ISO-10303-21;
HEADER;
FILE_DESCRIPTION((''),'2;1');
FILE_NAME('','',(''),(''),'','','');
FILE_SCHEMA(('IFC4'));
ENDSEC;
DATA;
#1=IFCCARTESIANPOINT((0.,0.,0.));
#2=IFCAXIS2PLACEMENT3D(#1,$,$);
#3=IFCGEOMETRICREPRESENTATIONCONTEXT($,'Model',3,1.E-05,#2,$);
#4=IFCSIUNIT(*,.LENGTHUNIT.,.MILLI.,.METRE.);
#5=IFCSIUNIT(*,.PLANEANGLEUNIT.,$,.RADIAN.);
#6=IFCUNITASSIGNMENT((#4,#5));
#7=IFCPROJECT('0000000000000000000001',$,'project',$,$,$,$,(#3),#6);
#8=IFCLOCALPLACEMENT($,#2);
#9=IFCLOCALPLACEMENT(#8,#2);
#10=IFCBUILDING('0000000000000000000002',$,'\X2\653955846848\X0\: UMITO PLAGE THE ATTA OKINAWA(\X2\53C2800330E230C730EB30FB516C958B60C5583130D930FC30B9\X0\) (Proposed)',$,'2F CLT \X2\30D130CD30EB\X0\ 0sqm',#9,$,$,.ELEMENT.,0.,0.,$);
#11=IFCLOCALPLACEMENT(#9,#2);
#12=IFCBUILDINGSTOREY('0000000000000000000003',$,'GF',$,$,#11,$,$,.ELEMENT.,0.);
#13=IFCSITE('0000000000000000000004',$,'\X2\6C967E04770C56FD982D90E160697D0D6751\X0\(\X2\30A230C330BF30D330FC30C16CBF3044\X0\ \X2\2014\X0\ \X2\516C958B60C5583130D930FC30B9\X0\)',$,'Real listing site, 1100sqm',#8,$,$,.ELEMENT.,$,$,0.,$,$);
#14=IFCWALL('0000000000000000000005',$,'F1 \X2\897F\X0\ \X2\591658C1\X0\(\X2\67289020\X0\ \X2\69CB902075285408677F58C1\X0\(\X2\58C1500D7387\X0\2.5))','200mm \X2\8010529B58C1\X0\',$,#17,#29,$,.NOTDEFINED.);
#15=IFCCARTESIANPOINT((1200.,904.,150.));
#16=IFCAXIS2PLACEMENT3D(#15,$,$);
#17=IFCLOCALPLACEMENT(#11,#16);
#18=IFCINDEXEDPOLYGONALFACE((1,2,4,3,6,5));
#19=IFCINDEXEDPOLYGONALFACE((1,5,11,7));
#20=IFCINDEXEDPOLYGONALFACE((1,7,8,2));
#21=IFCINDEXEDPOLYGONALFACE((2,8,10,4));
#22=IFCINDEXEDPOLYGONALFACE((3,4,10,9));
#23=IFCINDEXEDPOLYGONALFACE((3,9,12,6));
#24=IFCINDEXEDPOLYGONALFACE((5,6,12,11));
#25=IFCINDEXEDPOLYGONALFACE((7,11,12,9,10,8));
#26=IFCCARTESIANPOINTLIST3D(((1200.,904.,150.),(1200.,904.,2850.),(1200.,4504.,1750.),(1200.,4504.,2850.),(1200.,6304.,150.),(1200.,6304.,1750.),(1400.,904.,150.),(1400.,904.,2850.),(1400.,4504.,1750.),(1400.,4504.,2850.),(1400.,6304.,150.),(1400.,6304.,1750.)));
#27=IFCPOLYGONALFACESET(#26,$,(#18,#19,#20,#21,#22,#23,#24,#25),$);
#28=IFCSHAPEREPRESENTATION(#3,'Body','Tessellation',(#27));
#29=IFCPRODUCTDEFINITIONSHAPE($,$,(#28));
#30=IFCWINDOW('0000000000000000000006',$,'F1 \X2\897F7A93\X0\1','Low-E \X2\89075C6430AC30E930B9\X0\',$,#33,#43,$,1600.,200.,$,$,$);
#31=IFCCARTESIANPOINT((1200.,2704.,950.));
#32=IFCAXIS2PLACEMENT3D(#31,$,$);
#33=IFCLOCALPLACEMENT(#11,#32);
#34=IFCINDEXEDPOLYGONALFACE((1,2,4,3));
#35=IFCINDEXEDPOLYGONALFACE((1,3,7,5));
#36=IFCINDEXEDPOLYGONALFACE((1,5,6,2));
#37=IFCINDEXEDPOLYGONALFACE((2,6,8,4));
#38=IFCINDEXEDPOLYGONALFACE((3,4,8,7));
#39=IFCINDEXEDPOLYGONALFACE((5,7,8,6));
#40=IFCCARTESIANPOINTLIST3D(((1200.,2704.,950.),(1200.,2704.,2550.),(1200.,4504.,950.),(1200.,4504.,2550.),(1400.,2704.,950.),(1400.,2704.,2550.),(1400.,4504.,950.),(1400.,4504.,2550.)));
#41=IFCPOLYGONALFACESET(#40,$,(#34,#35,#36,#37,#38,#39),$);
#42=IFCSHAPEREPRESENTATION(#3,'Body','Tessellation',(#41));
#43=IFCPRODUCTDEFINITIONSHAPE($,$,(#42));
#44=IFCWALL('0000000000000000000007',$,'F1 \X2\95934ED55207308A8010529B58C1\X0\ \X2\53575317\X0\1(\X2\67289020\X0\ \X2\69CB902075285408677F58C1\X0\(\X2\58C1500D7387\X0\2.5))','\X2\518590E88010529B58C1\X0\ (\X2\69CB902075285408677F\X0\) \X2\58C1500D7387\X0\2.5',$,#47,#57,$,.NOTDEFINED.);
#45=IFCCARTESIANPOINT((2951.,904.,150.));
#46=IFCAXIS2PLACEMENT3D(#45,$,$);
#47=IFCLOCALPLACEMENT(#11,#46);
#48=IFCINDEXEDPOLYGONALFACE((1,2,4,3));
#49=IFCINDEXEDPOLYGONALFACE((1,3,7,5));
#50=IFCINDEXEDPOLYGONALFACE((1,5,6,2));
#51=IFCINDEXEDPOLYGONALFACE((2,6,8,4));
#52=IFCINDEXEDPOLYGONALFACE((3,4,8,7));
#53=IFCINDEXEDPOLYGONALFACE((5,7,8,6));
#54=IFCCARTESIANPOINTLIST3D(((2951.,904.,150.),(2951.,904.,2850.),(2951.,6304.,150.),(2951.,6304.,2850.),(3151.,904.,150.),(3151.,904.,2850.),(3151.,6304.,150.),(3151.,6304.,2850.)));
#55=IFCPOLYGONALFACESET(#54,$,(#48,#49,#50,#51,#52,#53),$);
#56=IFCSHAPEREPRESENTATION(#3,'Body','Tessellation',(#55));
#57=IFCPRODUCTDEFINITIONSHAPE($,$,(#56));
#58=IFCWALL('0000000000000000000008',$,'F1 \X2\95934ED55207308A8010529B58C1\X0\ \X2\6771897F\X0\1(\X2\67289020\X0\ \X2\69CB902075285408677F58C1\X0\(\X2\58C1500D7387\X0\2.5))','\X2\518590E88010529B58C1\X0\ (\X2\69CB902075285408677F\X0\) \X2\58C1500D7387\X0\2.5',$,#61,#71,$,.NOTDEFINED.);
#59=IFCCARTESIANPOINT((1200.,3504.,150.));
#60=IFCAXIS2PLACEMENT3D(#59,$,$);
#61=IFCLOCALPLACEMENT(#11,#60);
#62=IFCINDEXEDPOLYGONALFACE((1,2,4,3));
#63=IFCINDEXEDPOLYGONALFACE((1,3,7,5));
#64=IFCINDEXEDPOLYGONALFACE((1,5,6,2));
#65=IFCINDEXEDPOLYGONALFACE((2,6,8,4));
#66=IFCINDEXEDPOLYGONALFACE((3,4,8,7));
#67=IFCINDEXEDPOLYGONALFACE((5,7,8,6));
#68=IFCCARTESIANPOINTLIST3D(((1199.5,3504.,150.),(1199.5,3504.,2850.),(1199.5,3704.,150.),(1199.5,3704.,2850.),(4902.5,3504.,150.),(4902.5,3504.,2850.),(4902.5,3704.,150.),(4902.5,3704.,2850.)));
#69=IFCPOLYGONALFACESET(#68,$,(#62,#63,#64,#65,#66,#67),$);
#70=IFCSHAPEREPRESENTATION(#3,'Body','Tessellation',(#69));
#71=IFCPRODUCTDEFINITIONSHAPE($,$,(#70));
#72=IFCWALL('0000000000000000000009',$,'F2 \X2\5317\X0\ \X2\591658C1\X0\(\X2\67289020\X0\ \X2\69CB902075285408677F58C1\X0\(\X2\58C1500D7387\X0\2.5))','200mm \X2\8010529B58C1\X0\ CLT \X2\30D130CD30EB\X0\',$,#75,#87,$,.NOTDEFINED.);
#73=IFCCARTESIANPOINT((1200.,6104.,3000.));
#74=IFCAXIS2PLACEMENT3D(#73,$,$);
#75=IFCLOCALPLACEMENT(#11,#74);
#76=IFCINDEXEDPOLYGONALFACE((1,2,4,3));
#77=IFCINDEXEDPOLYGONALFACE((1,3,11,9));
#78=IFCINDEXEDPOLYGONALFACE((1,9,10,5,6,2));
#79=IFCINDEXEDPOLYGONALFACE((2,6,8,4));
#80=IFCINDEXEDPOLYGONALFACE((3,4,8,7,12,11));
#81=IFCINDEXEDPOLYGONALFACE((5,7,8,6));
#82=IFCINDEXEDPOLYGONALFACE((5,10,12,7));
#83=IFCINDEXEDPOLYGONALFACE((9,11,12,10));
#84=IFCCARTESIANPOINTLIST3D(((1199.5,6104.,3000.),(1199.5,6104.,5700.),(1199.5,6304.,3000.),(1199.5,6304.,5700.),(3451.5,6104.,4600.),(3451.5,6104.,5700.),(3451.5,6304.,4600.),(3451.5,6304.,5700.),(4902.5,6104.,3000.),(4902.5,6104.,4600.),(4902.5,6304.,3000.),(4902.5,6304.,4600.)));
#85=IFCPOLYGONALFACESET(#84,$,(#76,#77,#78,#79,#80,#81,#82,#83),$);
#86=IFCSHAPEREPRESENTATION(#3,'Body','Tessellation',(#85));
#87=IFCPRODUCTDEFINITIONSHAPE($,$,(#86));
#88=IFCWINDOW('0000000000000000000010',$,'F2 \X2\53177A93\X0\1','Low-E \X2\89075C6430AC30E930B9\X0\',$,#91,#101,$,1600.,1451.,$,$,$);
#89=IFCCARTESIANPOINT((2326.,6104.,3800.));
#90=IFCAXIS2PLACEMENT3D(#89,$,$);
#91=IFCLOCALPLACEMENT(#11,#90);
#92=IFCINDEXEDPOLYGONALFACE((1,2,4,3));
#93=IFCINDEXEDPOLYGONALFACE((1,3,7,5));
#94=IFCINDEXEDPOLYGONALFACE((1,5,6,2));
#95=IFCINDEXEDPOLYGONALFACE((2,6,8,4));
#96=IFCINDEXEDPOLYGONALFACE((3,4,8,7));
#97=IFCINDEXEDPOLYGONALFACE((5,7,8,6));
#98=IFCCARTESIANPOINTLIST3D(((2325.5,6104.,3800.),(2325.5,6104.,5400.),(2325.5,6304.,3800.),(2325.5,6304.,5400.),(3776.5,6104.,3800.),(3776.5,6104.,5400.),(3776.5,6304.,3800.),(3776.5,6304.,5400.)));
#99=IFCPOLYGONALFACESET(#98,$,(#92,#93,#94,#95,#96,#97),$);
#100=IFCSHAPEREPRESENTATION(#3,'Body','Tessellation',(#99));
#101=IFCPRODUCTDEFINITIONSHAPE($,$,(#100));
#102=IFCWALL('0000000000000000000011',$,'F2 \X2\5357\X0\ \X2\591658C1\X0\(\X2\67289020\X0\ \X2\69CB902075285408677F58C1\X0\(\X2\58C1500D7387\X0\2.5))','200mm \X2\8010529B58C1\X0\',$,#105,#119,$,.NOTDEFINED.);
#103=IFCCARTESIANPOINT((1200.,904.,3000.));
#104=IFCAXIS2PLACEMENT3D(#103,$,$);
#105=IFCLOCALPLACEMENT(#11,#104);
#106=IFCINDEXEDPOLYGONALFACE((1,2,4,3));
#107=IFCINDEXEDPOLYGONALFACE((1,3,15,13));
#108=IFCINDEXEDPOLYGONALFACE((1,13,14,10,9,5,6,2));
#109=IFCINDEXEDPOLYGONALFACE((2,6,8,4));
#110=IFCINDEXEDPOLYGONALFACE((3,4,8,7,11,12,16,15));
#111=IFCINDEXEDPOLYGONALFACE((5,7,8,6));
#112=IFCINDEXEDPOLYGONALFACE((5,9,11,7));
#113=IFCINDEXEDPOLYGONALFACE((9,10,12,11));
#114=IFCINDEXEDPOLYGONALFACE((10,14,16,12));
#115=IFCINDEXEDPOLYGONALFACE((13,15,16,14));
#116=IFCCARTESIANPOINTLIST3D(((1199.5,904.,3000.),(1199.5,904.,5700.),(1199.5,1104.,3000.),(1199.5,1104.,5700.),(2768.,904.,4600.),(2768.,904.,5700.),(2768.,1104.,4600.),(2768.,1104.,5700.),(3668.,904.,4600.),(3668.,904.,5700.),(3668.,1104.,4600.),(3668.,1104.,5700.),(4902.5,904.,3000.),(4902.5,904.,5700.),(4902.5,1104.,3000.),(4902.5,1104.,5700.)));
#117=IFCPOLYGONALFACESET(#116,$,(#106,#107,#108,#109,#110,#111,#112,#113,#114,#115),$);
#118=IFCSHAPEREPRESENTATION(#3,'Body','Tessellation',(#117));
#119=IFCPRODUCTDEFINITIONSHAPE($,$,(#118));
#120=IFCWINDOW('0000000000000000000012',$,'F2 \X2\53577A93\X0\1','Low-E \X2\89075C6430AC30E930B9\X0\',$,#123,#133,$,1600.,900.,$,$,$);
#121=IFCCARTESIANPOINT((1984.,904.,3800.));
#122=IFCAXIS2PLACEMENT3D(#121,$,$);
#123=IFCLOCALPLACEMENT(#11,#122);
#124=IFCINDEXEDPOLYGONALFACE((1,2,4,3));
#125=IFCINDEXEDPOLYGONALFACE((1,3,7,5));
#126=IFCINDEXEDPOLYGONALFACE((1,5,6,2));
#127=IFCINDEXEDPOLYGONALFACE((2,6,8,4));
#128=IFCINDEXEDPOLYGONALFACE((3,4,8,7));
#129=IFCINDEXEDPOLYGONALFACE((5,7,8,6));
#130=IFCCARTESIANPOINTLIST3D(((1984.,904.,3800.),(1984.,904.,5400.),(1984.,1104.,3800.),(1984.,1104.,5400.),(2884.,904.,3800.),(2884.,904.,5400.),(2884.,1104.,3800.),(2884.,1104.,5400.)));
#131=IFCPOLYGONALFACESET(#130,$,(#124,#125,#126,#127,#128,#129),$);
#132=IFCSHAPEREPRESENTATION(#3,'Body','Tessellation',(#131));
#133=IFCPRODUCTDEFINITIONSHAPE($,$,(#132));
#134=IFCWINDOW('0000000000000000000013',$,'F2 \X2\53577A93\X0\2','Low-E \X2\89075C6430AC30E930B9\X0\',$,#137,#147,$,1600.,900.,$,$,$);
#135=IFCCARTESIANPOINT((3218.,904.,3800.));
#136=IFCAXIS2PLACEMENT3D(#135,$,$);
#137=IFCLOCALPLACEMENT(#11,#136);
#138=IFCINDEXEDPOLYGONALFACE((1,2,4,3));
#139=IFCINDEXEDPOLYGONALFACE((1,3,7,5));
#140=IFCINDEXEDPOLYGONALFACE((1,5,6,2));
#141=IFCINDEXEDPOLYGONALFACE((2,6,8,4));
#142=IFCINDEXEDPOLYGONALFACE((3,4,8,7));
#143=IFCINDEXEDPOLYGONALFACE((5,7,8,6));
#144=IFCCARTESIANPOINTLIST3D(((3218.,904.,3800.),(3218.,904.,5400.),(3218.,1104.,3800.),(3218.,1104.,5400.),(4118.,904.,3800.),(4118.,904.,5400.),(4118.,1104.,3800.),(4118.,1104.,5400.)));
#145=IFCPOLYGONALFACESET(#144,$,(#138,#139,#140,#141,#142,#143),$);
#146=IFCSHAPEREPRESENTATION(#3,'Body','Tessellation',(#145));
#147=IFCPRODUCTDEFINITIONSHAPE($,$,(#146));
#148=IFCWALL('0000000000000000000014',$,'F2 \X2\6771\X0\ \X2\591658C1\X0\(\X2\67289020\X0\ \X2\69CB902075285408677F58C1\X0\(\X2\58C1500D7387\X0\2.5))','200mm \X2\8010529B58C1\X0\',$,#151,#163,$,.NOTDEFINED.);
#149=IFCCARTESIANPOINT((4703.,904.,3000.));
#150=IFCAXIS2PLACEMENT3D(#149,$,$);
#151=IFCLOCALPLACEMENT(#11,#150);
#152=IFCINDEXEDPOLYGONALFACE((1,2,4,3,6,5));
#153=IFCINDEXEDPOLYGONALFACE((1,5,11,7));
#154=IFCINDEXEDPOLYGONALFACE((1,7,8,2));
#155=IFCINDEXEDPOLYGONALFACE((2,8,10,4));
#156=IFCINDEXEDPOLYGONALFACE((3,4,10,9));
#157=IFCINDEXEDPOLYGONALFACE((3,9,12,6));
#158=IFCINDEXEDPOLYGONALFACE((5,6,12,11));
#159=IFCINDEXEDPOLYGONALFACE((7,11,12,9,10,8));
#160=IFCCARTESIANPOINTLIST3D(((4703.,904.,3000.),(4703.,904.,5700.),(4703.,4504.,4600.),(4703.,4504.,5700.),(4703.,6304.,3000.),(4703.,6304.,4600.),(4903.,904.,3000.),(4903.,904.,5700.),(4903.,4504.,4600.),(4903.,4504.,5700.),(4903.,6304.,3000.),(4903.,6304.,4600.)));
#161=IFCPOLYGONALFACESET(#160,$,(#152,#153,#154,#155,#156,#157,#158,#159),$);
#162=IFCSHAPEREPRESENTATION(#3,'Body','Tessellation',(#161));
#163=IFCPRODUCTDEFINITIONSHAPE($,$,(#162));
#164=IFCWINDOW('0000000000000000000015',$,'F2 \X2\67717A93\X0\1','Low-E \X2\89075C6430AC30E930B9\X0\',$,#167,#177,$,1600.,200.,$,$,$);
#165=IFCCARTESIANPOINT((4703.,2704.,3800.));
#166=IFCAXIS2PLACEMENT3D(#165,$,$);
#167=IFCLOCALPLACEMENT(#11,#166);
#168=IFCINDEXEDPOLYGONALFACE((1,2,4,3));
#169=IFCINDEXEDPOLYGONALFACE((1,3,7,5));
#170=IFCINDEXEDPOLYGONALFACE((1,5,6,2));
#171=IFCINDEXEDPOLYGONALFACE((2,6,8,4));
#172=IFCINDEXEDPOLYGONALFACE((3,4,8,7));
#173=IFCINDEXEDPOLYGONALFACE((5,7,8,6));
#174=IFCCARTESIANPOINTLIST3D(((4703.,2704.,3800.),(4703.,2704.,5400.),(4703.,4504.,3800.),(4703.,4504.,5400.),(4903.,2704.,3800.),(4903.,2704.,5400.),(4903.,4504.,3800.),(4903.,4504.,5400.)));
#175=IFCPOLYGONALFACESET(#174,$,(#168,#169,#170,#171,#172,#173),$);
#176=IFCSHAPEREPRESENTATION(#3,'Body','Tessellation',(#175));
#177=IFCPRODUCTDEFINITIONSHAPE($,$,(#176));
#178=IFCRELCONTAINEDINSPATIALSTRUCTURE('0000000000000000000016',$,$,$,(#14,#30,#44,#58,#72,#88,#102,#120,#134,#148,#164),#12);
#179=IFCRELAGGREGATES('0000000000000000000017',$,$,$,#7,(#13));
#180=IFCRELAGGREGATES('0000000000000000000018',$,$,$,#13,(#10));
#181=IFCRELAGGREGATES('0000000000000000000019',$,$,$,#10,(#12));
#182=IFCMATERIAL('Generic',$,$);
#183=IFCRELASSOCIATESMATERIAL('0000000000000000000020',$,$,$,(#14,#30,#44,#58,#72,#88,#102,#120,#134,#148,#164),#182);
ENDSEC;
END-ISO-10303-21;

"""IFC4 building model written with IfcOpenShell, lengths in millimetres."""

from ifc_helpers import new_model, si_unit, frame, frame_2d, origin, place, context, project, spatial, rectangle, extrude, material, element, fill, save


model = new_model("IFC4")

# Units and contexts
model_context = context("Model", 3, precision=1e-05, world=origin())
ifc_project = project(units=[si_unit("LENGTHUNIT", "METRE", prefix="MILLI"), si_unit("PLANEANGLEUNIT", "RADIAN")], contexts=[model_context])

# Site, building, storey
site_placement = place(None, origin())
site = spatial("IfcSite", under=ifc_project, at=site_placement, Name="沖縄県国頭郡恩納村(アッタビーチ沿い — 公開情報ベース)", ObjectType="Real listing site, 1100sqm", CompositionType="ELEMENT", RefElevation=0.0)
building_placement = place(site_placement, origin())
building = spatial("IfcBuilding", under=site, at=building_placement, Name="改善案: UMITO PLAGE THE ATTA OKINAWA(参考モデル・公開情報ベース) (Proposed)", ObjectType="2F CLT パネル 0sqm", CompositionType="ELEMENT", ElevationOfRefHeight=0.0, ElevationOfTerrain=0.0)
storey_placement = place(building_placement, origin())
storey = spatial("IfcBuildingStorey", under=building, at=storey_placement, Name="GF", CompositionType="ELEMENT", Elevation=0.0)

# Shared definitions
ifc_material_1 = material(Name="Generic")

# Wall, opening, window
wall_1_placement = place(storey_placement, frame((1200.0, 904.0, 150.0)))
wall_1 = element("IfcWall", 1, at=wall_1_placement, inside=storey, material=ifc_material_1, Name="F1 西 外壁(木造 構造用合板壁(壁倍率2.5))", Description="200mm 耐力壁", PredefinedType="NOTDEFINED", context=model_context, shape_type="SweptSolid", body=[
    extrude(rectangle(XDim=200.0, YDim=5400.0, at=frame_2d((100.0, 2700.0))), frame((1200.0, 904.0, 150.0)), (0.0, 0.0, 1.0), 2700.0),
])
opening_1_placement = place(storey_placement, frame((1200.0, 2704.0, 950.0)))
opening_1 = element("IfcOpeningElement", 2, at=opening_1_placement, cuts=wall_1, PredefinedType="NOTDEFINED", context=model_context, shape_type="SweptSolid", body=[
    extrude(rectangle(XDim=200.0, YDim=1800.0, at=frame_2d((100.0, 900.0))), frame((1200.0, 2704.0, 950.0)), (0.0, 0.0, 1.0), 1600.0),
])
window_1_placement = place(storey_placement, frame((1200.0, 2704.0, 950.0)))
window_1 = element("IfcWindow", 3, at=window_1_placement, inside=storey, material=ifc_material_1, Name="F1 西窓1", Description="Low-E 複層ガラス", OverallHeight=1600.0, OverallWidth=200.0, context=model_context, shape_type="SweptSolid", body=[
    extrude(rectangle(XDim=200.0, YDim=1800.0, at=frame_2d((100.0, 900.0))), frame((1200.0, 2704.0, 950.0)), (0.0, 0.0, 1.0), 1600.0),
])
fill(opening_1, window_1)

# Walls
wall_2_placement = place(storey_placement, frame((2951.0, 904.0, 150.0)))
element("IfcWall", 4, at=wall_2_placement, inside=storey, material=ifc_material_1, Name="F1 間仕切り耐力壁 南北1(木造 構造用合板壁(壁倍率2.5))", Description="内部耐力壁 (構造用合板) 壁倍率2.5", PredefinedType="NOTDEFINED", context=model_context, shape_type="SweptSolid", body=[
    extrude(rectangle(XDim=200.0, YDim=5400.0, at=frame_2d((100.0, 2700.0))), frame((2951.0, 904.0, 150.0)), (0.0, 0.0, 1.0), 2700.0),
])
wall_3_placement = place(storey_placement, frame((1200.0, 3504.0, 150.0)))
element("IfcWall", 5, at=wall_3_placement, inside=storey, material=ifc_material_1, Name="F1 間仕切り耐力壁 東西1(木造 構造用合板壁(壁倍率2.5))", Description="内部耐力壁 (構造用合板) 壁倍率2.5", PredefinedType="NOTDEFINED", context=model_context, shape_type="SweptSolid", body=[
    extrude(rectangle(XDim=3703.0, YDim=200.0, at=frame_2d((1851.0, 100.0))), frame((1200.0, 3504.0, 150.0)), (0.0, 0.0, 1.0), 2700.0),
])

# Wall, opening, window
wall_4_placement = place(storey_placement, frame((1200.0, 6104.0, 3000.0)))
wall_4 = element("IfcWall", 6, at=wall_4_placement, inside=storey, material=ifc_material_1, Name="F2 北 外壁(木造 構造用合板壁(壁倍率2.5))", Description="200mm 耐力壁 CLT パネル", PredefinedType="NOTDEFINED", context=model_context, shape_type="SweptSolid", body=[
    extrude(rectangle(XDim=3703.0, YDim=200.0, at=frame_2d((1851.0, 100.0))), frame((1200.0, 6104.0, 3000.0)), (0.0, 0.0, 1.0), 2700.0),
])
opening_2_placement = place(storey_placement, frame((2326.0, 6104.0, 3800.0)))
opening_2 = element("IfcOpeningElement", 7, at=opening_2_placement, cuts=wall_4, PredefinedType="NOTDEFINED", context=model_context, shape_type="SweptSolid", body=[
    extrude(rectangle(XDim=1451.0, YDim=200.0, at=frame_2d((725.0, 100.0))), frame((2326.0, 6104.0, 3800.0)), (0.0, 0.0, 1.0), 1600.0),
])
window_2_placement = place(storey_placement, frame((2326.0, 6104.0, 3800.0)))
window_2 = element("IfcWindow", 8, at=window_2_placement, inside=storey, material=ifc_material_1, Name="F2 北窓1", Description="Low-E 複層ガラス", OverallHeight=1600.0, OverallWidth=1451.0, context=model_context, shape_type="SweptSolid", body=[
    extrude(rectangle(XDim=1451.0, YDim=200.0, at=frame_2d((725.0, 100.0))), frame((2326.0, 6104.0, 3800.0)), (0.0, 0.0, 1.0), 1600.0),
])
fill(opening_2, window_2)

# Wall, openings, windows
wall_5_placement = place(storey_placement, frame((1200.0, 904.0, 3000.0)))
wall_5 = element("IfcWall", 9, at=wall_5_placement, inside=storey, material=ifc_material_1, Name="F2 南 外壁(木造 構造用合板壁(壁倍率2.5))", Description="200mm 耐力壁", PredefinedType="NOTDEFINED", context=model_context, shape_type="SweptSolid", body=[
    extrude(rectangle(XDim=3703.0, YDim=200.0, at=frame_2d((1851.0, 100.0))), frame((1200.0, 904.0, 3000.0)), (0.0, 0.0, 1.0), 2700.0),
])
opening_3_placement = place(storey_placement, frame((1984.0, 904.0, 3800.0)))
opening_3 = element("IfcOpeningElement", 10, at=opening_3_placement, cuts=wall_5, PredefinedType="NOTDEFINED", context=model_context, shape_type="SweptSolid", body=[
    extrude(rectangle(XDim=900.0, YDim=200.0, at=frame_2d((450.0, 100.0))), frame((1984.0, 904.0, 3800.0)), (0.0, 0.0, 1.0), 1600.0),
])
opening_4_placement = place(storey_placement, frame((3218.0, 904.0, 3800.0)))
opening_4 = element("IfcOpeningElement", 11, at=opening_4_placement, cuts=wall_5, PredefinedType="NOTDEFINED", context=model_context, shape_type="SweptSolid", body=[
    extrude(rectangle(XDim=900.0, YDim=200.0, at=frame_2d((450.0, 100.0))), frame((3218.0, 904.0, 3800.0)), (0.0, 0.0, 1.0), 1600.0),
])
window_3_placement = place(storey_placement, frame((1984.0, 904.0, 3800.0)))
window_3 = element("IfcWindow", 12, at=window_3_placement, inside=storey, material=ifc_material_1, Name="F2 南窓1", Description="Low-E 複層ガラス", OverallHeight=1600.0, OverallWidth=900.0, context=model_context, shape_type="SweptSolid", body=[
    extrude(rectangle(XDim=900.0, YDim=200.0, at=frame_2d((450.0, 100.0))), frame((1984.0, 904.0, 3800.0)), (0.0, 0.0, 1.0), 1600.0),
])
fill(opening_3, window_3)
window_4_placement = place(storey_placement, frame((3218.0, 904.0, 3800.0)))
window_4 = element("IfcWindow", 13, at=window_4_placement, inside=storey, material=ifc_material_1, Name="F2 南窓2", Description="Low-E 複層ガラス", OverallHeight=1600.0, OverallWidth=900.0, context=model_context, shape_type="SweptSolid", body=[
    extrude(rectangle(XDim=900.0, YDim=200.0, at=frame_2d((450.0, 100.0))), frame((3218.0, 904.0, 3800.0)), (0.0, 0.0, 1.0), 1600.0),
])
fill(opening_4, window_4)

# Wall, opening, window
wall_6_placement = place(storey_placement, frame((4703.0, 904.0, 3000.0)))
wall_6 = element("IfcWall", 14, at=wall_6_placement, inside=storey, material=ifc_material_1, Name="F2 東 外壁(木造 構造用合板壁(壁倍率2.5))", Description="200mm 耐力壁", PredefinedType="NOTDEFINED", context=model_context, shape_type="SweptSolid", body=[
    extrude(rectangle(XDim=200.0, YDim=5400.0, at=frame_2d((100.0, 2700.0))), frame((4703.0, 904.0, 3000.0)), (0.0, 0.0, 1.0), 2700.0),
])
opening_5_placement = place(storey_placement, frame((4703.0, 2704.0, 3800.0)))
opening_5 = element("IfcOpeningElement", 15, at=opening_5_placement, cuts=wall_6, PredefinedType="NOTDEFINED", context=model_context, shape_type="SweptSolid", body=[
    extrude(rectangle(XDim=200.0, YDim=1800.0, at=frame_2d((100.0, 900.0))), frame((4703.0, 2704.0, 3800.0)), (0.0, 0.0, 1.0), 1600.0),
])
window_5_placement = place(storey_placement, frame((4703.0, 2704.0, 3800.0)))
window_5 = element("IfcWindow", 16, at=window_5_placement, inside=storey, material=ifc_material_1, Name="F2 東窓1", Description="Low-E 複層ガラス", OverallHeight=1600.0, OverallWidth=200.0, context=model_context, shape_type="SweptSolid", body=[
    extrude(rectangle(XDim=200.0, YDim=1800.0, at=frame_2d((100.0, 900.0))), frame((4703.0, 2704.0, 3800.0)), (0.0, 0.0, 1.0), 1600.0),
])
fill(opening_5, window_5)

save(model, "model.ifc")
